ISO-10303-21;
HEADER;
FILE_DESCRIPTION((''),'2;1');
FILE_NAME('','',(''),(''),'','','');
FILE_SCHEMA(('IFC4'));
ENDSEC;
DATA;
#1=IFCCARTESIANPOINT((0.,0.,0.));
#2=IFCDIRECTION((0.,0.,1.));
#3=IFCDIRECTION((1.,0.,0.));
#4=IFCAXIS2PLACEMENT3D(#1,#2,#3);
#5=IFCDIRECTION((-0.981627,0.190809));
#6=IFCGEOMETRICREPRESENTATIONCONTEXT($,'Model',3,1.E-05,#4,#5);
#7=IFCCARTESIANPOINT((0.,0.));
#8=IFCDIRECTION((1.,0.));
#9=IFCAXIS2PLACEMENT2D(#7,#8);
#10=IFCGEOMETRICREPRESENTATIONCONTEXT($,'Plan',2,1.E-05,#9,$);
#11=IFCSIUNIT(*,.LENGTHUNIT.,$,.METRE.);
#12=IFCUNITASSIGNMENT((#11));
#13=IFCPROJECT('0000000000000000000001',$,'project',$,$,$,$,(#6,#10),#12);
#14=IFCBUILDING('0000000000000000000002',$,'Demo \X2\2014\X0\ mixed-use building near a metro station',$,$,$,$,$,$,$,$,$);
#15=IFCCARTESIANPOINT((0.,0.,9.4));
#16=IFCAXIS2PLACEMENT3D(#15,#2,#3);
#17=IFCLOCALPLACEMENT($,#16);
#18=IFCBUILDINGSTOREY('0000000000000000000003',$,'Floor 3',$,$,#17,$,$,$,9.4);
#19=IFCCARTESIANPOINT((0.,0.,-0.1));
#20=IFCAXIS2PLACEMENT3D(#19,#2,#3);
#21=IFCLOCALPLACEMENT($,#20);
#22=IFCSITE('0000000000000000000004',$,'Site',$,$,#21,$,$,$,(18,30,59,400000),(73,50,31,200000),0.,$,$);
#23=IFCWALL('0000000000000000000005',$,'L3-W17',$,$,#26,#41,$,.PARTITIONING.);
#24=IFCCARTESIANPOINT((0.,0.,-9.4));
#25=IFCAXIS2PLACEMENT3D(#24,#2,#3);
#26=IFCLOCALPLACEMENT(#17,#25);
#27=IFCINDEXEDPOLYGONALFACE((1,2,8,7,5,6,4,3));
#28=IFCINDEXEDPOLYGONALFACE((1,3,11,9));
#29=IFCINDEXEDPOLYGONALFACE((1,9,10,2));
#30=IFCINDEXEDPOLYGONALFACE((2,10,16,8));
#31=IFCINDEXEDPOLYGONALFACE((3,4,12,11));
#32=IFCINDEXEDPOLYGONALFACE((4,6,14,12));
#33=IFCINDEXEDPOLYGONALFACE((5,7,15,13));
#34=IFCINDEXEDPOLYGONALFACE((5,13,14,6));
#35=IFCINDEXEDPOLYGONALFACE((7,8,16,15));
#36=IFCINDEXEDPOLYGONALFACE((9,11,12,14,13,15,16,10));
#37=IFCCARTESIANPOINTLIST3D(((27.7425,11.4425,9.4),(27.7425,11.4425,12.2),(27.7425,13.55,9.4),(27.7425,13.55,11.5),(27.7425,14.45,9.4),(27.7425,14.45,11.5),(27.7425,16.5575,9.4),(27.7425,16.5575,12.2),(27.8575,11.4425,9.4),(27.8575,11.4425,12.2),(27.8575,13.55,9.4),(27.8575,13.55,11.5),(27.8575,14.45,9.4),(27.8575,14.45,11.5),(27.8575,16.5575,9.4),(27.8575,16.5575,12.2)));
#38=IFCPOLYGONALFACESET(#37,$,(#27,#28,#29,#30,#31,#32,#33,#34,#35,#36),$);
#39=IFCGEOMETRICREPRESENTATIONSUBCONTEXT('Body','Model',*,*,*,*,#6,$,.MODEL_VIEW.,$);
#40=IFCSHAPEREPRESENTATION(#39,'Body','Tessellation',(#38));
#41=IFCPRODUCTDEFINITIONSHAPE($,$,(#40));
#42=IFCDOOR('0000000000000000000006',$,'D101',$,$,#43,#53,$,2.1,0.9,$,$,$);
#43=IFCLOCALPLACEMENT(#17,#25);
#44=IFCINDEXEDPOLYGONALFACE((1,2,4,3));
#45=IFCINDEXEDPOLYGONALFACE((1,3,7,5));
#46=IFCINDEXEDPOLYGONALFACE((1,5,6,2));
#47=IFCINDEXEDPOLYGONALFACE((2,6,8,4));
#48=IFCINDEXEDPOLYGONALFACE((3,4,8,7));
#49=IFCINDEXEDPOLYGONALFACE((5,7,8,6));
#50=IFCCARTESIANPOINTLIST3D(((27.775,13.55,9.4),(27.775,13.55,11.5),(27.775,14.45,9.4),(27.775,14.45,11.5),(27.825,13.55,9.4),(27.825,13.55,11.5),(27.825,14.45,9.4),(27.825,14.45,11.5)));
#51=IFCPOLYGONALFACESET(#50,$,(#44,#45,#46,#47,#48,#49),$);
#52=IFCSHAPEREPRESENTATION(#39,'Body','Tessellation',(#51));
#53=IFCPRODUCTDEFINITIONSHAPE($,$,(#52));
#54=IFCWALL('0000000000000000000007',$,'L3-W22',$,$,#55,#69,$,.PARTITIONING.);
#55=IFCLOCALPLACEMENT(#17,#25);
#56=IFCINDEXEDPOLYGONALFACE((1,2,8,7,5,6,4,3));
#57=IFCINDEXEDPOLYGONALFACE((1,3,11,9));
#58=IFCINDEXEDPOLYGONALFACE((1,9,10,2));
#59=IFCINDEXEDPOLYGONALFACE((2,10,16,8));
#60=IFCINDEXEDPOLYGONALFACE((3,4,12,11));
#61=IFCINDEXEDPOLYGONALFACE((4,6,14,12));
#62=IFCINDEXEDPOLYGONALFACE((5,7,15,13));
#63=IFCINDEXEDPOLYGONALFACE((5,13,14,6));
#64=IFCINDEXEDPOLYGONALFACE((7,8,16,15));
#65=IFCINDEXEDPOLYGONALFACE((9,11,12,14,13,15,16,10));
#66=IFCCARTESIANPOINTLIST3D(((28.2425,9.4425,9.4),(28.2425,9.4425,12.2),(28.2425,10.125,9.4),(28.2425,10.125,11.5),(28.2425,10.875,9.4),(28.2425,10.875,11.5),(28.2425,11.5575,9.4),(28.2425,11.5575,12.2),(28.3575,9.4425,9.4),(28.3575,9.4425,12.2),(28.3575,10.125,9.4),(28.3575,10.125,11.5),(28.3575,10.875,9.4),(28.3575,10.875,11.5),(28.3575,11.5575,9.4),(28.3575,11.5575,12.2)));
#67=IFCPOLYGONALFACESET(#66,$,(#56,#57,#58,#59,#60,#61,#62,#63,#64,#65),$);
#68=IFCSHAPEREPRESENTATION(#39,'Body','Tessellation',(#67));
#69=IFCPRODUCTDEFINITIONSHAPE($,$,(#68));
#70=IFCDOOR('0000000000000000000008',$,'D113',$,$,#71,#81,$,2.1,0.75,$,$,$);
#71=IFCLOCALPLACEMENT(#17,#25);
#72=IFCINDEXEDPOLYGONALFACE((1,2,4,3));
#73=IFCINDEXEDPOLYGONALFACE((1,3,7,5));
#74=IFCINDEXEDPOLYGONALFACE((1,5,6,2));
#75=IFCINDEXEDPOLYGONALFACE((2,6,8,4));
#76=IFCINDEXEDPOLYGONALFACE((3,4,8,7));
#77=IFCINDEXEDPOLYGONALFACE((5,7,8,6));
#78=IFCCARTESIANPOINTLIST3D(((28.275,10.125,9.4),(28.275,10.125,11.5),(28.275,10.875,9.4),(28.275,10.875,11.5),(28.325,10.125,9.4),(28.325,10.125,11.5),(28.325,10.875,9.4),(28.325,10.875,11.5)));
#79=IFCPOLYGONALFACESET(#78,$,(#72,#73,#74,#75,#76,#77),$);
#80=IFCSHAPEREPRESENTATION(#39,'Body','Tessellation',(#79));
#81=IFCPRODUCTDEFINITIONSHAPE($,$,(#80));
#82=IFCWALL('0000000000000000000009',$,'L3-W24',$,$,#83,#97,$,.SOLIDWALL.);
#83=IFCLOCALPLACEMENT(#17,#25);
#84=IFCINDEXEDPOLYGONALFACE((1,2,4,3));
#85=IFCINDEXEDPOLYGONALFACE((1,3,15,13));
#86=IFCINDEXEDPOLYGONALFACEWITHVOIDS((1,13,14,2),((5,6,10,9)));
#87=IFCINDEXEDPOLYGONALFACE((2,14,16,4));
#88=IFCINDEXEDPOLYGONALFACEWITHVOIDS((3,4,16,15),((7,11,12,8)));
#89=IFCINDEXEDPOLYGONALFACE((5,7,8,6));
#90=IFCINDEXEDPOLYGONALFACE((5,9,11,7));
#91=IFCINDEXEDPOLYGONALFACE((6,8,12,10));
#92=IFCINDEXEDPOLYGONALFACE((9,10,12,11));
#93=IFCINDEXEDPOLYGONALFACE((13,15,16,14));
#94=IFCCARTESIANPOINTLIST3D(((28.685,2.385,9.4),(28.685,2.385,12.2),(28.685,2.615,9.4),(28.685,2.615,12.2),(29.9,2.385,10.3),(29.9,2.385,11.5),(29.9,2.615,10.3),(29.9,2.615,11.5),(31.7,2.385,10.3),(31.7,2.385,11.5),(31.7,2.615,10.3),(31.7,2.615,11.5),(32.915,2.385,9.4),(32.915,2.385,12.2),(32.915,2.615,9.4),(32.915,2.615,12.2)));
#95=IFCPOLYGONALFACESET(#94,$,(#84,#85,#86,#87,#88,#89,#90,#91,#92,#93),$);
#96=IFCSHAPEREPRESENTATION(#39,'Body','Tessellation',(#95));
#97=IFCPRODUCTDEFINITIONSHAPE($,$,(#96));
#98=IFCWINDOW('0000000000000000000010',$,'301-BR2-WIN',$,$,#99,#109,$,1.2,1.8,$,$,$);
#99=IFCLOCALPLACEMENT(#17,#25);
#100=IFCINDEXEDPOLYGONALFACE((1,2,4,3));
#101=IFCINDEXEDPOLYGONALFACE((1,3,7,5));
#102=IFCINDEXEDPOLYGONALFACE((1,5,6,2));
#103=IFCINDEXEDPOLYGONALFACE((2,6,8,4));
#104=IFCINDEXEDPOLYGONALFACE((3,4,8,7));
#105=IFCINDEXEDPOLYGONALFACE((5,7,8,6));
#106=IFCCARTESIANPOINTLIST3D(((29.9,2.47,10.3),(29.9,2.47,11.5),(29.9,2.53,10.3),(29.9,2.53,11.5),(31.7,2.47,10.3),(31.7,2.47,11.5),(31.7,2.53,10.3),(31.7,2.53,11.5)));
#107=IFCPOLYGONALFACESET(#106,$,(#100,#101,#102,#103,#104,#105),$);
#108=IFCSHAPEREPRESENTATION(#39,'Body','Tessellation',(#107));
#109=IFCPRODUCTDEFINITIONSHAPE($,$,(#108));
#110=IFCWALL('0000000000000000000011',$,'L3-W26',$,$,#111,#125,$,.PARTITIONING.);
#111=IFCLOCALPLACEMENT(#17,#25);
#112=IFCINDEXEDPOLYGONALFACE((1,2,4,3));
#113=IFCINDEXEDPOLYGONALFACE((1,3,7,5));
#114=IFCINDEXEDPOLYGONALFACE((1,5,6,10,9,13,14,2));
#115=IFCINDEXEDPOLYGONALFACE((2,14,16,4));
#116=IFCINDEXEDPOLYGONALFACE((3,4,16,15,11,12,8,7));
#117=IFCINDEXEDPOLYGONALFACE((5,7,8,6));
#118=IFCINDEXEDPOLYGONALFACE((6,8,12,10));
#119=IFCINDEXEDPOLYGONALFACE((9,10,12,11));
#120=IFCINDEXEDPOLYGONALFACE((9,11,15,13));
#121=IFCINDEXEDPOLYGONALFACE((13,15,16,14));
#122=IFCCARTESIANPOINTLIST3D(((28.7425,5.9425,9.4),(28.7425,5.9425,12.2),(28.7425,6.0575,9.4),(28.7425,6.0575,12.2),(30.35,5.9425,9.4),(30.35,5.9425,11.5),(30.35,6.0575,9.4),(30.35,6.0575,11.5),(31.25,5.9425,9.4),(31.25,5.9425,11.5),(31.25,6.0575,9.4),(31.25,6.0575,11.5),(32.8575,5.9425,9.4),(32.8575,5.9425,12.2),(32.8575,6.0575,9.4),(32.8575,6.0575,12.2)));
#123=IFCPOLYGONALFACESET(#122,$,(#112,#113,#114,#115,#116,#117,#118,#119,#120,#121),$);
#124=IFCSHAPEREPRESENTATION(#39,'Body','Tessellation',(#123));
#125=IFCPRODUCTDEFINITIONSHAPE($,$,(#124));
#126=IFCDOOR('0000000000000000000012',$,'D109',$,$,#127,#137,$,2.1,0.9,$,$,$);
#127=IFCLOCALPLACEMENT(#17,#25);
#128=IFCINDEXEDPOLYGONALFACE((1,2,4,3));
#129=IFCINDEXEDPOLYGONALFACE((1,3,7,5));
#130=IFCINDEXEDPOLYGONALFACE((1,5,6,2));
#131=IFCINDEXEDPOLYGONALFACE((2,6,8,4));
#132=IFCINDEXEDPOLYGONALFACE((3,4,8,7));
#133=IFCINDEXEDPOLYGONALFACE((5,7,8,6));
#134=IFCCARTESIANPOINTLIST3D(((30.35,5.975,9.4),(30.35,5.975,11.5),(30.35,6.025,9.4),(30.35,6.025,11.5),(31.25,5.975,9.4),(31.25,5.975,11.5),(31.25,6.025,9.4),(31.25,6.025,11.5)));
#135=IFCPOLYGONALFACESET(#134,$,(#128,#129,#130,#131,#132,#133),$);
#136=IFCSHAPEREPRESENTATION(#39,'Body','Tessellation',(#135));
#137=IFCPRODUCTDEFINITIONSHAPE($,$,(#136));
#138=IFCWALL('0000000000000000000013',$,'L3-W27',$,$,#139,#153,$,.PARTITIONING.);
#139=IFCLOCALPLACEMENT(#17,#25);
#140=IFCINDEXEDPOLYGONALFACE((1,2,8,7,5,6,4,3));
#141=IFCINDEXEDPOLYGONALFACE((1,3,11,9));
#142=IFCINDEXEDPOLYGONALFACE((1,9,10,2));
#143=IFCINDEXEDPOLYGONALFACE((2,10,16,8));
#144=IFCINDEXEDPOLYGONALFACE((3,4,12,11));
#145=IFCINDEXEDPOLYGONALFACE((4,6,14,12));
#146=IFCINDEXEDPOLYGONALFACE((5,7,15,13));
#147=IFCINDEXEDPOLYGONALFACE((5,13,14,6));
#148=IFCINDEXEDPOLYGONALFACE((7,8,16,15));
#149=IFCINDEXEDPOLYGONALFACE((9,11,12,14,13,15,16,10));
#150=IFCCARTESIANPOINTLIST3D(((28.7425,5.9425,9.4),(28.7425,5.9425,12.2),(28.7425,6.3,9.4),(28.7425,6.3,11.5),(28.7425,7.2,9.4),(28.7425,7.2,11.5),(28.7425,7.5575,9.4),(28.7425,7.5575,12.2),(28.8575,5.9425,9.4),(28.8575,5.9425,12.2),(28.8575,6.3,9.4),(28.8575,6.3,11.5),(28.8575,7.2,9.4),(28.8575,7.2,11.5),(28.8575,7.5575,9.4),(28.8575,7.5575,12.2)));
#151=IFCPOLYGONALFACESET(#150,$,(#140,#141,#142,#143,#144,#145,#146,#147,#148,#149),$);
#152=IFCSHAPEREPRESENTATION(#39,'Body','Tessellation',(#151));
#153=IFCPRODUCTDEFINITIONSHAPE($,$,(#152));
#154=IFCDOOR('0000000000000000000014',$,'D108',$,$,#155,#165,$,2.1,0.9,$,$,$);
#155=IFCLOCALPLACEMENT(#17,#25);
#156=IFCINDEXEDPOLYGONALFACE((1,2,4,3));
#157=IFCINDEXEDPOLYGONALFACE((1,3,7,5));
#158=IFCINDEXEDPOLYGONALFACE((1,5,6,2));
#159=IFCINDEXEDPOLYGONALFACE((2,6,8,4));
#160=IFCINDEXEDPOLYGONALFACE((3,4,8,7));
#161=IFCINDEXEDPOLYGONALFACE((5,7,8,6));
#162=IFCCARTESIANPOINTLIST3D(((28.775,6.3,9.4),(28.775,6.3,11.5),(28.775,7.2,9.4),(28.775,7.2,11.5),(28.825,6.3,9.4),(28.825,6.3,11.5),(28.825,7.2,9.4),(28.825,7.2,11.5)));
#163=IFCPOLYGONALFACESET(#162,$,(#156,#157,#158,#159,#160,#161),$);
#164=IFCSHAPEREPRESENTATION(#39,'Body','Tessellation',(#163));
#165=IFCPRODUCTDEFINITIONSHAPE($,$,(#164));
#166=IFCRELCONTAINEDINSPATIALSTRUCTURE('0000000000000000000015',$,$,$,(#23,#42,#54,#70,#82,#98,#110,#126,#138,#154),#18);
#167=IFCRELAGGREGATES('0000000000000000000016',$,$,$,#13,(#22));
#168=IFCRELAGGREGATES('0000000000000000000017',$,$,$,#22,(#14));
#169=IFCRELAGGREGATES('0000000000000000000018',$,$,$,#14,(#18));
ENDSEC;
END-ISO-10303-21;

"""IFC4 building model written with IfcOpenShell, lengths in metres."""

from ifc_helpers import new_model, si_unit, direction, frame, origin_with_axes, origin_2d_with_axis, place, context, subcontext, project, spatial, line, indexed_curve, outline, extrude, element, fill, save


model = new_model("IFC4")

# Units and contexts
model_context = context("Model", 3, precision=1e-05, world=origin_with_axes(), true_north=direction((-0.981627, 0.190809)))
plan_context = context("Plan", 2, precision=1e-05, world=origin_2d_with_axis())
body_context = subcontext(model_context, "Body", "Model", "MODEL_VIEW")
ifc_project = project(units=[si_unit("LENGTHUNIT", "METRE")], contexts=[model_context, plan_context])

# Site, building, storey
site_placement = place(None, frame((0.0, 0.0, -0.1), z_axis=(0.0, 0.0, 1.0), x_axis=(1.0, 0.0, 0.0)))
site = spatial("IfcSite", under=ifc_project, at=site_placement, Name="Site", RefLatitude=(18, 30, 59, 400000), RefLongitude=(73, 50, 31, 200000), RefElevation=0.0)
building = spatial("IfcBuilding", under=site, Name="Demo — mixed-use building near a metro station")
storey_placement = place(None, frame((0.0, 0.0, 9.4), z_axis=(0.0, 0.0, 1.0), x_axis=(1.0, 0.0, 0.0)))
storey = spatial("IfcBuildingStorey", under=building, at=storey_placement, Name="Floor 3", Elevation=9.4)

# Wall, opening, door
wall_1_placement = place(storey_placement, frame((0.0, 0.0, -9.4), z_axis=(0.0, 0.0, 1.0), x_axis=(1.0, 0.0, 0.0)))
wall_1 = element("IfcWall", 1, at=wall_1_placement, inside=storey, Name="L3-W17", PredefinedType="PARTITIONING", context=body_context, shape_type="SweptSolid", body=[
    extrude(outline(indexed_curve([(27.7425, 11.4425), (27.7425, 16.5575), (27.8575, 16.5575), (27.8575, 11.4425)], segments=[line(1, 2, 3, 4, 1)])), frame((0.0, 0.0, 9.4), z_axis=(0.0, 0.0, 1.0), x_axis=(1.0, 0.0, 0.0)), (0.0, 0.0, 1.0), 2.8),
])
opening_1_placement = place(wall_1_placement, origin_with_axes())
opening_1 = element("IfcOpeningElement", 2, at=opening_1_placement, cuts=wall_1, context=body_context, shape_type="SweptSolid", body=[
    extrude(outline(indexed_curve([(27.6925, 13.55), (27.6925, 14.45), (27.9075, 14.45), (27.9075, 13.55)], segments=[line(1, 2, 3, 4, 1)])), frame((0.0, 0.0, 9.4), z_axis=(0.0, 0.0, 1.0), x_axis=(1.0, 0.0, 0.0)), (0.0, 0.0, 1.0), 2.1),
])
door_1_placement = place(storey_placement, frame((0.0, 0.0, -9.4), z_axis=(0.0, 0.0, 1.0), x_axis=(1.0, 0.0, 0.0)))
door_1 = element("IfcDoor", 3, at=door_1_placement, inside=storey, Name="D101", OverallHeight=2.1, OverallWidth=0.9, context=body_context, shape_type="SweptSolid", body=[
    extrude(outline(indexed_curve([(27.775, 13.55), (27.775, 14.45), (27.825, 14.45), (27.825, 13.55)], segments=[line(1, 2, 3, 4, 1)])), frame((0.0, 0.0, 9.4), z_axis=(0.0, 0.0, 1.0), x_axis=(1.0, 0.0, 0.0)), (0.0, 0.0, 1.0), 2.1),
])
fill(opening_1, door_1)

# Wall, opening, door
wall_2_placement = place(storey_placement, frame((0.0, 0.0, -9.4), z_axis=(0.0, 0.0, 1.0), x_axis=(1.0, 0.0, 0.0)))
wall_2 = element("IfcWall", 4, at=wall_2_placement, inside=storey, Name="L3-W22", PredefinedType="PARTITIONING", context=body_context, shape_type="SweptSolid", body=[
    extrude(outline(indexed_curve([(28.2425, 9.4425), (28.2425, 11.5575), (28.3575, 11.5575), (28.3575, 9.4425)], segments=[line(1, 2, 3, 4, 1)])), frame((0.0, 0.0, 9.4), z_axis=(0.0, 0.0, 1.0), x_axis=(1.0, 0.0, 0.0)), (0.0, 0.0, 1.0), 2.8),
])
opening_2_placement = place(wall_2_placement, origin_with_axes())
opening_2 = element("IfcOpeningElement", 5, at=opening_2_placement, cuts=wall_2, context=body_context, shape_type="SweptSolid", body=[
    extrude(outline(indexed_curve([(28.1925, 10.125), (28.1925, 10.875), (28.4075, 10.875), (28.4075, 10.125)], segments=[line(1, 2, 3, 4, 1)])), frame((0.0, 0.0, 9.4), z_axis=(0.0, 0.0, 1.0), x_axis=(1.0, 0.0, 0.0)), (0.0, 0.0, 1.0), 2.1),
])
door_2_placement = place(storey_placement, frame((0.0, 0.0, -9.4), z_axis=(0.0, 0.0, 1.0), x_axis=(1.0, 0.0, 0.0)))
door_2 = element("IfcDoor", 6, at=door_2_placement, inside=storey, Name="D113", OverallHeight=2.1, OverallWidth=0.75, context=body_context, shape_type="SweptSolid", body=[
    extrude(outline(indexed_curve([(28.275, 10.125), (28.275, 10.875), (28.325, 10.875), (28.325, 10.125)], segments=[line(1, 2, 3, 4, 1)])), frame((0.0, 0.0, 9.4), z_axis=(0.0, 0.0, 1.0), x_axis=(1.0, 0.0, 0.0)), (0.0, 0.0, 1.0), 2.1),
])
fill(opening_2, door_2)

# Wall, opening, window
wall_3_placement = place(storey_placement, frame((0.0, 0.0, -9.4), z_axis=(0.0, 0.0, 1.0), x_axis=(1.0, 0.0, 0.0)))
wall_3 = element("IfcWall", 7, at=wall_3_placement, inside=storey, Name="L3-W24", PredefinedType="SOLIDWALL", context=body_context, shape_type="SweptSolid", body=[
    extrude(outline(indexed_curve([(28.685, 2.615), (32.915, 2.615), (32.915, 2.385), (28.685, 2.385)], segments=[line(1, 2, 3, 4, 1)])), frame((0.0, 0.0, 9.4), z_axis=(0.0, 0.0, 1.0), x_axis=(1.0, 0.0, 0.0)), (0.0, 0.0, 1.0), 2.8),
])
opening_3_placement = place(wall_3_placement, origin_with_axes())
opening_3 = element("IfcOpeningElement", 8, at=opening_3_placement, cuts=wall_3, context=body_context, shape_type="SweptSolid", body=[
    extrude(outline(indexed_curve([(29.9, 2.665), (31.7, 2.665), (31.7, 2.335), (29.9, 2.335)], segments=[line(1, 2, 3, 4, 1)])), frame((0.0, 0.0, 10.3), z_axis=(0.0, 0.0, 1.0), x_axis=(1.0, 0.0, 0.0)), (0.0, 0.0, 1.0), 1.2),
])
window_placement = place(storey_placement, frame((0.0, 0.0, -9.4), z_axis=(0.0, 0.0, 1.0), x_axis=(1.0, 0.0, 0.0)))
window = element("IfcWindow", 9, at=window_placement, inside=storey, Name="301-BR2-WIN", OverallHeight=1.2, OverallWidth=1.8, context=body_context, shape_type="SweptSolid", body=[
    extrude(outline(indexed_curve([(29.9, 2.53), (31.7, 2.53), (31.7, 2.47), (29.9, 2.47)], segments=[line(1, 2, 3, 4, 1)])), frame((0.0, 0.0, 10.3), z_axis=(0.0, 0.0, 1.0), x_axis=(1.0, 0.0, 0.0)), (0.0, 0.0, 1.0), 1.2),
])
fill(opening_3, window)

# Walls, openings, doors
wall_4_placement = place(storey_placement, frame((0.0, 0.0, -9.4), z_axis=(0.0, 0.0, 1.0), x_axis=(1.0, 0.0, 0.0)))
wall_4 = element("IfcWall", 10, at=wall_4_placement, inside=storey, Name="L3-W26", PredefinedType="PARTITIONING", context=body_context, shape_type="SweptSolid", body=[
    extrude(outline(indexed_curve([(32.8575, 5.9425), (28.7425, 5.9425), (28.7425, 6.0575), (32.8575, 6.0575)], segments=[line(1, 2, 3, 4, 1)])), frame((0.0, 0.0, 9.4), z_axis=(0.0, 0.0, 1.0), x_axis=(1.0, 0.0, 0.0)), (0.0, 0.0, 1.0), 2.8),
])
opening_4_placement = place(wall_4_placement, origin_with_axes())
opening_4 = element("IfcOpeningElement", 11, at=opening_4_placement, cuts=wall_4, context=body_context, shape_type="SweptSolid", body=[
    extrude(outline(indexed_curve([(31.25, 5.8925), (30.35, 5.8925), (30.35, 6.1075), (31.25, 6.1075)], segments=[line(1, 2, 3, 4, 1)])), frame((0.0, 0.0, 9.4), z_axis=(0.0, 0.0, 1.0), x_axis=(1.0, 0.0, 0.0)), (0.0, 0.0, 1.0), 2.1),
])
door_3_placement = place(storey_placement, frame((0.0, 0.0, -9.4), z_axis=(0.0, 0.0, 1.0), x_axis=(1.0, 0.0, 0.0)))
door_3 = element("IfcDoor", 12, at=door_3_placement, inside=storey, Name="D109", OverallHeight=2.1, OverallWidth=0.9, context=body_context, shape_type="SweptSolid", body=[
    extrude(outline(indexed_curve([(31.25, 5.975), (30.35, 5.975), (30.35, 6.025), (31.25, 6.025)], segments=[line(1, 2, 3, 4, 1)])), frame((0.0, 0.0, 9.4), z_axis=(0.0, 0.0, 1.0), x_axis=(1.0, 0.0, 0.0)), (0.0, 0.0, 1.0), 2.1),
])
fill(opening_4, door_3)
wall_5_placement = place(storey_placement, frame((0.0, 0.0, -9.4), z_axis=(0.0, 0.0, 1.0), x_axis=(1.0, 0.0, 0.0)))
wall_5 = element("IfcWall", 13, at=wall_5_placement, inside=storey, Name="L3-W27", PredefinedType="PARTITIONING", context=body_context, shape_type="SweptSolid", body=[
    extrude(outline(indexed_curve([(28.7425, 5.9425), (28.7425, 7.5575), (28.8575, 7.5575), (28.8575, 5.9425)], segments=[line(1, 2, 3, 4, 1)])), frame((0.0, 0.0, 9.4), z_axis=(0.0, 0.0, 1.0), x_axis=(1.0, 0.0, 0.0)), (0.0, 0.0, 1.0), 2.8),
])
opening_5_placement = place(wall_5_placement, origin_with_axes())
opening_5 = element("IfcOpeningElement", 14, at=opening_5_placement, cuts=wall_5, context=body_context, shape_type="SweptSolid", body=[
    extrude(outline(indexed_curve([(28.6925, 6.3), (28.6925, 7.2), (28.9075, 7.2), (28.9075, 6.3)], segments=[line(1, 2, 3, 4, 1)])), frame((0.0, 0.0, 9.4), z_axis=(0.0, 0.0, 1.0), x_axis=(1.0, 0.0, 0.0)), (0.0, 0.0, 1.0), 2.1),
])
door_4_placement = place(storey_placement, frame((0.0, 0.0, -9.4), z_axis=(0.0, 0.0, 1.0), x_axis=(1.0, 0.0, 0.0)))
door_4 = element("IfcDoor", 15, at=door_4_placement, inside=storey, Name="D108", OverallHeight=2.1, OverallWidth=0.9, context=body_context, shape_type="SweptSolid", body=[
    extrude(outline(indexed_curve([(28.775, 6.3), (28.775, 7.2), (28.825, 7.2), (28.825, 6.3)], segments=[line(1, 2, 3, 4, 1)])), frame((0.0, 0.0, 9.4), z_axis=(0.0, 0.0, 1.0), x_axis=(1.0, 0.0, 0.0)), (0.0, 0.0, 1.0), 2.1),
])
fill(opening_5, door_4)

save(model, "model.ifc")
